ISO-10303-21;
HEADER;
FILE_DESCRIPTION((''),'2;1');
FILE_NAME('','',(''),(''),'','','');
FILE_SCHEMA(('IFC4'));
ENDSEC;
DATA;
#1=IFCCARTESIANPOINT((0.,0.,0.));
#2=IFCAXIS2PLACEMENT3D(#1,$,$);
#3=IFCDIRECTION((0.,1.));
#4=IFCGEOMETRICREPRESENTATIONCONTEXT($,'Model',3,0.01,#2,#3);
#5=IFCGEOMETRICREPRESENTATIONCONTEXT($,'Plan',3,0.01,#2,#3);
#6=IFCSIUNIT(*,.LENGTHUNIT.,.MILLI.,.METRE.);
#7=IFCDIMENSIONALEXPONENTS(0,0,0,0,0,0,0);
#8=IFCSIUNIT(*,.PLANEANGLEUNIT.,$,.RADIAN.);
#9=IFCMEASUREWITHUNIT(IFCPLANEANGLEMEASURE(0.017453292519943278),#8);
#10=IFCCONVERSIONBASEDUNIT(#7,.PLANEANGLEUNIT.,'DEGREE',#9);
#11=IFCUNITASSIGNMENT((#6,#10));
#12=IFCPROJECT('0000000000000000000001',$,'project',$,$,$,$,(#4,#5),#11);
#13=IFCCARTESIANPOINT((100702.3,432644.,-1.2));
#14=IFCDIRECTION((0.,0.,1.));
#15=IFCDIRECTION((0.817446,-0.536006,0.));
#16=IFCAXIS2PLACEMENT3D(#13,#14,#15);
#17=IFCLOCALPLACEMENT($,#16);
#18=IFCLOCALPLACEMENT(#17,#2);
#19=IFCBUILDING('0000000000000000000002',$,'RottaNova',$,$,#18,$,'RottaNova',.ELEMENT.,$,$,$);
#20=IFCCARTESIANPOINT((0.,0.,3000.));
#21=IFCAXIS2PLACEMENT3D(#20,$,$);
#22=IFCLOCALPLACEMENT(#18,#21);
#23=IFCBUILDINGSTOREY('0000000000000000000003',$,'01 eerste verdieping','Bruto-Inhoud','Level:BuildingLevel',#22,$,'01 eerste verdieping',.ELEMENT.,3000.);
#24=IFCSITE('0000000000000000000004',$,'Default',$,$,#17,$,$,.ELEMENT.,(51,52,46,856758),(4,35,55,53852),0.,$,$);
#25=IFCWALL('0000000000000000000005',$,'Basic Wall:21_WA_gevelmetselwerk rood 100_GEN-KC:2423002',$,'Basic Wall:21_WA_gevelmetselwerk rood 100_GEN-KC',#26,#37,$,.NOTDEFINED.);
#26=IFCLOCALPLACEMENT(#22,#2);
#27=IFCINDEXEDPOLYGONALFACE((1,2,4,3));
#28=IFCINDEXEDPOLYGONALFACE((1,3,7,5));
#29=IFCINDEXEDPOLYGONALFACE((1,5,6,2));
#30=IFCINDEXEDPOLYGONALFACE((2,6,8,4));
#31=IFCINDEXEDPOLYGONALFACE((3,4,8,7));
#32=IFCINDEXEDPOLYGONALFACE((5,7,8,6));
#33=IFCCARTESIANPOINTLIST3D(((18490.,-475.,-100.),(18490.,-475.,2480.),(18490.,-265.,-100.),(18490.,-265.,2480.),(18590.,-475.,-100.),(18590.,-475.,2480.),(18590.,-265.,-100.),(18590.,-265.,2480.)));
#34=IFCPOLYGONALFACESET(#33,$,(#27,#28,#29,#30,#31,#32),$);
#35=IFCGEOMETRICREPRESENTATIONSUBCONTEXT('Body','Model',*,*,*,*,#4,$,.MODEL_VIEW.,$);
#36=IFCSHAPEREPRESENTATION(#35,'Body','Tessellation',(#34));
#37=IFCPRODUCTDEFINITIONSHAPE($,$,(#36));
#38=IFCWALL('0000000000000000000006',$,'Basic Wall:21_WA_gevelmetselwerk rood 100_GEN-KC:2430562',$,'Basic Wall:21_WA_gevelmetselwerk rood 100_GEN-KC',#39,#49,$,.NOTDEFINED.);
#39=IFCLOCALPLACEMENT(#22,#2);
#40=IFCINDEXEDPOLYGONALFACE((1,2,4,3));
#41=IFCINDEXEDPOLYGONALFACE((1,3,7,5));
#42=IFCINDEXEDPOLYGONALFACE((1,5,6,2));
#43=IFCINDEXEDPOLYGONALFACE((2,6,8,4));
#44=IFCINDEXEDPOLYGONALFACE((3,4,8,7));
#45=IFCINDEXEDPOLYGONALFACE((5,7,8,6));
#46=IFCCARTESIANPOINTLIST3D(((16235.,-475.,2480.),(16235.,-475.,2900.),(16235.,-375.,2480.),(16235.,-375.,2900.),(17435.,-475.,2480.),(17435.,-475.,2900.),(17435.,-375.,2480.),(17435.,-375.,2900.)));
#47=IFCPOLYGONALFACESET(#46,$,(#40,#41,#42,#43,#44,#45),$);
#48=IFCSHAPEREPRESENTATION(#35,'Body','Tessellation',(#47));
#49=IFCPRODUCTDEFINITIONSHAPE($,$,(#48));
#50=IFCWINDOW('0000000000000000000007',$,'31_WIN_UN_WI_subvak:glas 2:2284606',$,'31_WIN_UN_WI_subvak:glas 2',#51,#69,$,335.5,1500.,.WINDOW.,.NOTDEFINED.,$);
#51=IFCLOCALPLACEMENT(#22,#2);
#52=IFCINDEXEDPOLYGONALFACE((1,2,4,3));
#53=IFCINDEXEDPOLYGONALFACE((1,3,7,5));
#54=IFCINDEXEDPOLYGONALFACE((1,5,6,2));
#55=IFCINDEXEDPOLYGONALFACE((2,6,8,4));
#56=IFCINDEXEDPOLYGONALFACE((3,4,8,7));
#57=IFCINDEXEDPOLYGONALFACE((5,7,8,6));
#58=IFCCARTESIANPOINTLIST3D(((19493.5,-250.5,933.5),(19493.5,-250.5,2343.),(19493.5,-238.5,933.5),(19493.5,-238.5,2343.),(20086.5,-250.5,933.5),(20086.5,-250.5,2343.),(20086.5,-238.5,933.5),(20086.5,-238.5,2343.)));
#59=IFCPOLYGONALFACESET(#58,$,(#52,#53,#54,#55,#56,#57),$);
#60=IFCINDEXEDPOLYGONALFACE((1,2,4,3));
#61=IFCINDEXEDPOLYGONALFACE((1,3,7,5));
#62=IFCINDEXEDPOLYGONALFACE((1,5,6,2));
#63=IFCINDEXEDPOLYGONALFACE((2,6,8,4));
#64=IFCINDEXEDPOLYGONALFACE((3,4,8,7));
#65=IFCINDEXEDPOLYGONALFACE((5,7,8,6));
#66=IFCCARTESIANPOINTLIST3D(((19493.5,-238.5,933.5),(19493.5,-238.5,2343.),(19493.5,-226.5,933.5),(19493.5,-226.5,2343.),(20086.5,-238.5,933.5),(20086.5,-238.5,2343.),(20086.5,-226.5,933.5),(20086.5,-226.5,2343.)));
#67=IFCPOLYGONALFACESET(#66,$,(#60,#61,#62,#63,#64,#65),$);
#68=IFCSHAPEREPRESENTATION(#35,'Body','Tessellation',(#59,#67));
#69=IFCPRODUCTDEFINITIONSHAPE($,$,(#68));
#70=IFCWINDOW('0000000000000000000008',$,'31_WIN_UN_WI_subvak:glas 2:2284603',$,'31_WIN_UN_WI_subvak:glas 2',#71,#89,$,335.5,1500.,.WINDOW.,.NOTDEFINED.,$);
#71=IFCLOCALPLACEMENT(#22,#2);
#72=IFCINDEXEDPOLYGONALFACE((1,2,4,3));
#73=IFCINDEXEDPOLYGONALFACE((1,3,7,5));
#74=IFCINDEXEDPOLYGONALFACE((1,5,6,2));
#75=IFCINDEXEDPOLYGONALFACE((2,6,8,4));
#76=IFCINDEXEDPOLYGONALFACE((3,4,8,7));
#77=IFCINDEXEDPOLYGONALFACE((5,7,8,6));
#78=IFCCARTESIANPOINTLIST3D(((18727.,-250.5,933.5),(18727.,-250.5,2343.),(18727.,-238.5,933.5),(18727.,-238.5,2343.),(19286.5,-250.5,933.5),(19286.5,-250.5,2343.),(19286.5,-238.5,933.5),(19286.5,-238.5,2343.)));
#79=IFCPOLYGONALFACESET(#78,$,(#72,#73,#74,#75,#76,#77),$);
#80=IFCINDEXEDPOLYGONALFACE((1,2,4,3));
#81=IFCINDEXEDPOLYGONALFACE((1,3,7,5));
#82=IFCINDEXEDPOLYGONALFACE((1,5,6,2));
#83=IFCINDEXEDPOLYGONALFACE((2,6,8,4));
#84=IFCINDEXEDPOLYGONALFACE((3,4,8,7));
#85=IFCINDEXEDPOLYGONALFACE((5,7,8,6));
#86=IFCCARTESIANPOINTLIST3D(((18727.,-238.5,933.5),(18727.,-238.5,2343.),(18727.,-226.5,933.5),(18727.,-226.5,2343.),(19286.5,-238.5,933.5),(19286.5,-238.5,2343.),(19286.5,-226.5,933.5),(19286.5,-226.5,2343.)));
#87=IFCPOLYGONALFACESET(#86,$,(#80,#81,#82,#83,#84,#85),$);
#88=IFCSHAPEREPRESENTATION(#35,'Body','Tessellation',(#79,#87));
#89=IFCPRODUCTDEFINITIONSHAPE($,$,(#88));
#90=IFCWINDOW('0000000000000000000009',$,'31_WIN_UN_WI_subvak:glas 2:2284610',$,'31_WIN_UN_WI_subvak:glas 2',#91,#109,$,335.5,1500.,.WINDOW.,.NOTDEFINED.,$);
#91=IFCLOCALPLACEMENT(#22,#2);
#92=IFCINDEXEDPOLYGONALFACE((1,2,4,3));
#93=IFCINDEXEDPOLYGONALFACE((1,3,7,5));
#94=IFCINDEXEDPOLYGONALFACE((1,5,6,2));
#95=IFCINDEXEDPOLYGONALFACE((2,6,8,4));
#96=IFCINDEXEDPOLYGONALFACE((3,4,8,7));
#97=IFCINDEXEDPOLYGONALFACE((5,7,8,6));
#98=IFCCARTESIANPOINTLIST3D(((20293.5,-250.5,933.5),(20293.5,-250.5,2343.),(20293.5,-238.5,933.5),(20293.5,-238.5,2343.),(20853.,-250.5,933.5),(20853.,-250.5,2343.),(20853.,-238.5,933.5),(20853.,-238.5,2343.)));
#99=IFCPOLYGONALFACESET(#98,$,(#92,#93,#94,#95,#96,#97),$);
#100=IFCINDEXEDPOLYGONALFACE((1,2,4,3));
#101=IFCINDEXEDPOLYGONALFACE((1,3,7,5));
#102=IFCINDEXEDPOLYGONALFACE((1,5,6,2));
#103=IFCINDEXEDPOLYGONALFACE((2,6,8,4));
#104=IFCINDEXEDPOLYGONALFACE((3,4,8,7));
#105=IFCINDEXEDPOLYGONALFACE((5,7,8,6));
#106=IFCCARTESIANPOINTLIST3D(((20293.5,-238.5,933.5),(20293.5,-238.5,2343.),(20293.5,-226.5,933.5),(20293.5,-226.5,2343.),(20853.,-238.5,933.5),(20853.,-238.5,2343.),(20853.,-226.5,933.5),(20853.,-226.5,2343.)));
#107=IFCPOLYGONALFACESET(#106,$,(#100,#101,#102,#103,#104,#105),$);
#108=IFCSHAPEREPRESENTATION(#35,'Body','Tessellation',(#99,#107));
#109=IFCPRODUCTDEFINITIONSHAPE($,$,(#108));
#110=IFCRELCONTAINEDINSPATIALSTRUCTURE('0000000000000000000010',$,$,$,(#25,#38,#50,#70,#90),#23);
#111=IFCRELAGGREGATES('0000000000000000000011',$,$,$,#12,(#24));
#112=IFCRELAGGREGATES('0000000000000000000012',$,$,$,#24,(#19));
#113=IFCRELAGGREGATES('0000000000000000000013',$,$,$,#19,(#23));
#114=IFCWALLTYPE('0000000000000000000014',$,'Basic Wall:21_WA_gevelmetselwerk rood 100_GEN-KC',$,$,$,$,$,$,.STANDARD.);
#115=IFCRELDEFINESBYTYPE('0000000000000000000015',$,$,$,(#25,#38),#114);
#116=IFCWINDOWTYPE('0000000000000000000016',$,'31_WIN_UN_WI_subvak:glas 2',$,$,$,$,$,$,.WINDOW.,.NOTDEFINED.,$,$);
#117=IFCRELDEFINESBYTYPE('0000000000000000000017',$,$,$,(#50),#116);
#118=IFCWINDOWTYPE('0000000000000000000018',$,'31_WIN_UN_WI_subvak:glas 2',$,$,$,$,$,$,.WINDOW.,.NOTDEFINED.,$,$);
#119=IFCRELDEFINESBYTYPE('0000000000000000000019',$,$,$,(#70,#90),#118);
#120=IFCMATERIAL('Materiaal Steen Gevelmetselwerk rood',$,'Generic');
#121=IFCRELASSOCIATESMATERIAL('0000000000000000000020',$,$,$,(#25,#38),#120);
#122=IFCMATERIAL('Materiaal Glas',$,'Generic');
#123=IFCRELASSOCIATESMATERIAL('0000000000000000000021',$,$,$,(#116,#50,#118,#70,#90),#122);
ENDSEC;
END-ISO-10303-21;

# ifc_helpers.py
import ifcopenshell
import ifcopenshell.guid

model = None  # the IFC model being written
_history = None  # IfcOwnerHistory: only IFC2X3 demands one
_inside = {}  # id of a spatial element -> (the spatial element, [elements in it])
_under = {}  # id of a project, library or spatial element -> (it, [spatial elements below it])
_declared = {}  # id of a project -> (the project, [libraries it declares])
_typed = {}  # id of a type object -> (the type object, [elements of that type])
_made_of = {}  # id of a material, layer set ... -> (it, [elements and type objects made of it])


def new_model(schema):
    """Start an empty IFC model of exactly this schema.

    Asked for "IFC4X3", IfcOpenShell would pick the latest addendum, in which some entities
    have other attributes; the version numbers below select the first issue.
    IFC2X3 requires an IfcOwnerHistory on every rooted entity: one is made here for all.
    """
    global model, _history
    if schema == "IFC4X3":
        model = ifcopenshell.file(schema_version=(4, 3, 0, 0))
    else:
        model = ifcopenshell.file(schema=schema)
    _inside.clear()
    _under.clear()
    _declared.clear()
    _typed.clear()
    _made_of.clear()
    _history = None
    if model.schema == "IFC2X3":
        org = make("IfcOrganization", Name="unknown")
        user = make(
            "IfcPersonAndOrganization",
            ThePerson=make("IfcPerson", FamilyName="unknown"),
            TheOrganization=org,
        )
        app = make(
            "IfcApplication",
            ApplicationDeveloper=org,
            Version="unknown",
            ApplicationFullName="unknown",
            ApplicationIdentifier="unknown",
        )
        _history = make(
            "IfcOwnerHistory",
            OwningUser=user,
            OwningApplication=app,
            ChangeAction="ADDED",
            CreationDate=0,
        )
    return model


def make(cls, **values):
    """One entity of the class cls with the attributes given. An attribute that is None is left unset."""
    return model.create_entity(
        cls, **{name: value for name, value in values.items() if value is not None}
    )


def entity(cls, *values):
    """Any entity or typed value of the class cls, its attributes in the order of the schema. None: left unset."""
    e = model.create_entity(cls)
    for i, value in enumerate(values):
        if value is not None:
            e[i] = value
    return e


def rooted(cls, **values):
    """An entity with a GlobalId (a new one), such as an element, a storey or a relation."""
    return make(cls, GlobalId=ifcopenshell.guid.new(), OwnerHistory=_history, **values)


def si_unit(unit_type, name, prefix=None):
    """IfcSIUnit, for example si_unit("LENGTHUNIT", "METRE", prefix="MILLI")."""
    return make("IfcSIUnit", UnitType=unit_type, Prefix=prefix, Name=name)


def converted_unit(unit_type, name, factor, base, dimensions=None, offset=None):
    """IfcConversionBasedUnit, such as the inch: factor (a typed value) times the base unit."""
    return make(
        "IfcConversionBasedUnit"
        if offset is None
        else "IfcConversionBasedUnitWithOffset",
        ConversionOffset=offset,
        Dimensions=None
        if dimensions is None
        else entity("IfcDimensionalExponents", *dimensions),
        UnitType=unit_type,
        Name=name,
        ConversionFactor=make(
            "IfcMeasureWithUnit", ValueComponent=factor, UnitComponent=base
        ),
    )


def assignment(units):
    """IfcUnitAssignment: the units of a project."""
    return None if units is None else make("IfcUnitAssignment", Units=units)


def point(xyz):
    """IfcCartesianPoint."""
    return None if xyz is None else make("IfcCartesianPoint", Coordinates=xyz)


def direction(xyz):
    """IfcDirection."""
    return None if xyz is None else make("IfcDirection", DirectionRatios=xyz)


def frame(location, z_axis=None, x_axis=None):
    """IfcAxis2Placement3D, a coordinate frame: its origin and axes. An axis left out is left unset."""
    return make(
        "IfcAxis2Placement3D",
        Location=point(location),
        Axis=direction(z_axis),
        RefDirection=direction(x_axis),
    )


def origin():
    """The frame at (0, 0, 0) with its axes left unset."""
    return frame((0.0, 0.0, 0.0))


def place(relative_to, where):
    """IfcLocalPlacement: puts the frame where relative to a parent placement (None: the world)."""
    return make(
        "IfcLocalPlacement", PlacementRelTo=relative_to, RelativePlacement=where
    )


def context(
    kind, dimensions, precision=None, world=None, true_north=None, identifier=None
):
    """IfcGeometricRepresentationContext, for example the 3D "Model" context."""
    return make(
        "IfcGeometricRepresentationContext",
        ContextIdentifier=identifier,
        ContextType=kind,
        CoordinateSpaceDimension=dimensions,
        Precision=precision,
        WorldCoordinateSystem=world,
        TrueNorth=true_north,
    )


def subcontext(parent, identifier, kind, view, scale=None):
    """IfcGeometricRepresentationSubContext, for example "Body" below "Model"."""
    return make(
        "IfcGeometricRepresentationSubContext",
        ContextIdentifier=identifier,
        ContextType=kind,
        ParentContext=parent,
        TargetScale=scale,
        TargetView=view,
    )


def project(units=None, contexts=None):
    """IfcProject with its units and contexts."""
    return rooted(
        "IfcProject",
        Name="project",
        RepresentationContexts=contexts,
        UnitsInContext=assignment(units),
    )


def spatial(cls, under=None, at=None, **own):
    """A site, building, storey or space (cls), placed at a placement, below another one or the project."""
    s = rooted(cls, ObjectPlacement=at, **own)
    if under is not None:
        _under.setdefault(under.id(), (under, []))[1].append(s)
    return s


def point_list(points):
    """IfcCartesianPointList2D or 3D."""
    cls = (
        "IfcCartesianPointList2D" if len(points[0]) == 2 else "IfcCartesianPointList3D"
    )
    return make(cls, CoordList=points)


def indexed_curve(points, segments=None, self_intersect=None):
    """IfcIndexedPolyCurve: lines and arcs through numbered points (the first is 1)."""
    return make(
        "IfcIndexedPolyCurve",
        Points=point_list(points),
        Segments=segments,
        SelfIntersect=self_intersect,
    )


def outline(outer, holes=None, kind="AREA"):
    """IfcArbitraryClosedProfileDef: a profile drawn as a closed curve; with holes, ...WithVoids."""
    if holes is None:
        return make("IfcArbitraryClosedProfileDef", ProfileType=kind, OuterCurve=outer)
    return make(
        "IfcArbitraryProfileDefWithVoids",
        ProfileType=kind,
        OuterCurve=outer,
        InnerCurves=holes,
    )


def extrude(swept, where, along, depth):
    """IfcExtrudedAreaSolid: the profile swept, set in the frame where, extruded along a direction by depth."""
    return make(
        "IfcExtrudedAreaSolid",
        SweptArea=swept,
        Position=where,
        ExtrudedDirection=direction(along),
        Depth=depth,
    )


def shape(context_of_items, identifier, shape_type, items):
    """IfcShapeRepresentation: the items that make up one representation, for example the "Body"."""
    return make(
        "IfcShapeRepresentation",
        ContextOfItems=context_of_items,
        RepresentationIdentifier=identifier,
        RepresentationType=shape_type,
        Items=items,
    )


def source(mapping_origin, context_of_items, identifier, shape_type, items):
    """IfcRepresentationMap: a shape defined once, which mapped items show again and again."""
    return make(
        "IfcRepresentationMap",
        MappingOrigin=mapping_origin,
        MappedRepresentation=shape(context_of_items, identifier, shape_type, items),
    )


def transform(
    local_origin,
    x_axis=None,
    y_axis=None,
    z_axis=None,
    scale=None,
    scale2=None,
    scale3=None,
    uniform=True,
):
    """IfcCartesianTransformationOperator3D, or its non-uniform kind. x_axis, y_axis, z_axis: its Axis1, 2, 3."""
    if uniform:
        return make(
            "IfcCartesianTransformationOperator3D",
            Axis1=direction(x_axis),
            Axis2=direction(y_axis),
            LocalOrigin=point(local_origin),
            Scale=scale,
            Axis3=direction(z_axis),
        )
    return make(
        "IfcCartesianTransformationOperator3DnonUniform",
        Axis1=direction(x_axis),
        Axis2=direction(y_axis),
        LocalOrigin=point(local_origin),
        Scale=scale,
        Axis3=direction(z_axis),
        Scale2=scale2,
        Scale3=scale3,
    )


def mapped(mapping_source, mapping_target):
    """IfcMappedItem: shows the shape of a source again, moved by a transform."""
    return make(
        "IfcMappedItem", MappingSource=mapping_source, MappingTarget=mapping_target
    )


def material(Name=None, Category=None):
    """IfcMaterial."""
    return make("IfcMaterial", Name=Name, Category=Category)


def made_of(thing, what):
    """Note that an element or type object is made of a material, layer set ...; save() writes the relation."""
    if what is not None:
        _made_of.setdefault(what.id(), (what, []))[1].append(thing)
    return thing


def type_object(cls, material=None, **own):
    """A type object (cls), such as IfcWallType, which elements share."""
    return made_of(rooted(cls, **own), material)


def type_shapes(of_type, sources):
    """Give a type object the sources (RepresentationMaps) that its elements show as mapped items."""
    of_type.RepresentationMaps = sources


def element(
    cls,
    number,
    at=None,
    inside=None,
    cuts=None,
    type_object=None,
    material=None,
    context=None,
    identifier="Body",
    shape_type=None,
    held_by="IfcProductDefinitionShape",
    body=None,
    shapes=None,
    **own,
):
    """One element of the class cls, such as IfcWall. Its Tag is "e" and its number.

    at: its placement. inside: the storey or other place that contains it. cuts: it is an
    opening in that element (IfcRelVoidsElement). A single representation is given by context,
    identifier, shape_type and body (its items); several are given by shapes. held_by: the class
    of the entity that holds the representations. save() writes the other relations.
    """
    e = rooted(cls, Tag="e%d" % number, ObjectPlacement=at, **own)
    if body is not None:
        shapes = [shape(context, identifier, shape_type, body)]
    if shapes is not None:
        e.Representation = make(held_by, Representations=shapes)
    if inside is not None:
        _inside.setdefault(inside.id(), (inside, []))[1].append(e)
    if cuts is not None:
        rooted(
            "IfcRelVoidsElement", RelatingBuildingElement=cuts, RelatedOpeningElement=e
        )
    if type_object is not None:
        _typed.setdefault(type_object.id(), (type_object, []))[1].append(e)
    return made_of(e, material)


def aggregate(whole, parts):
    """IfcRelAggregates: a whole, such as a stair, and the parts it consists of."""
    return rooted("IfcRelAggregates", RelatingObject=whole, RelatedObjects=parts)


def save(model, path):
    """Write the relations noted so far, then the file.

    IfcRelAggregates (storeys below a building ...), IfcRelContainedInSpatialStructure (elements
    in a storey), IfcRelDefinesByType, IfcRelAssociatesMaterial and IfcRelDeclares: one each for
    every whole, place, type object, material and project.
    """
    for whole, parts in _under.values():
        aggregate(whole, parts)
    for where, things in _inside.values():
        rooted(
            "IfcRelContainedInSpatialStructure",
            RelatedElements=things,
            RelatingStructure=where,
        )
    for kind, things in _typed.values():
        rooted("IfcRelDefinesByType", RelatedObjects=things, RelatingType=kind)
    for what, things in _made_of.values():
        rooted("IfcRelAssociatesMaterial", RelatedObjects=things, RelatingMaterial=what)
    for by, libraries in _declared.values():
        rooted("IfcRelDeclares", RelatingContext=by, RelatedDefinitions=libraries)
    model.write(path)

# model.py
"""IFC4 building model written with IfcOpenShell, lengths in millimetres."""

from ifc_helpers import new_model, entity, si_unit, converted_unit, direction, frame, origin, place, context, subcontext, project, spatial, indexed_curve, outline, extrude, source, transform, mapped, material, type_object, type_shapes, element, save


model = new_model("IFC4")

# Units and contexts
model_context = context("Model", 3, precision=0.01, world=origin(), true_north=direction((0.0, 1.0)))
plan_context = context("Plan", 3, precision=0.01, world=origin(), true_north=direction((0.0, 1.0)))
body_context = subcontext(model_context, "Body", "Model", "MODEL_VIEW")
ifc_project = project(units=[si_unit("LENGTHUNIT", "METRE", prefix="MILLI"), converted_unit("PLANEANGLEUNIT", "DEGREE", entity("IfcPlaneAngleMeasure", 0.017453292519943278), si_unit("PLANEANGLEUNIT", "RADIAN"), dimensions=[0, 0, 0, 0, 0, 0, 0])], contexts=[model_context, plan_context])

# Site, building, storey
site_placement = place(None, frame((100702.3, 432644.0, -1.2), z_axis=(0.0, 0.0, 1.0), x_axis=(0.817446, -0.536006, 0.0)))
site = spatial("IfcSite", under=ifc_project, at=site_placement, Name="Default", CompositionType="ELEMENT", RefLatitude=(51, 52, 46, 856758), RefLongitude=(4, 35, 55, 53852), RefElevation=0.0)
building_placement = place(site_placement, origin())
building = spatial("IfcBuilding", under=site, at=building_placement, Name="RottaNova", LongName="RottaNova", CompositionType="ELEMENT")
storey_placement = place(building_placement, frame((0.0, 0.0, 3000.0)))
storey = spatial("IfcBuildingStorey", under=building, at=storey_placement, Name="01 eerste verdieping", Description="Bruto-Inhoud", ObjectType="Level:BuildingLevel", LongName="01 eerste verdieping", CompositionType="ELEMENT", Elevation=3000.0)

# Shared definitions
ifc_material_1 = material(Name="Materiaal Glas", Category="Generic")

# Walls
ifc_material_2 = material(Name="Materiaal Steen Gevelmetselwerk rood", Category="Generic")
wall_type = type_object("IfcWallType", Name="Basic Wall:21_WA_gevelmetselwerk rood 100_GEN-KC", PredefinedType="STANDARD")
wall_1_placement = place(storey_placement, frame((18540.0, -265.0, -100.0), z_axis=(0.0, 0.0, 1.0), x_axis=(0.0, -1.0, 0.0)))
element("IfcWall", 1, at=wall_1_placement, inside=storey, type_object=wall_type, material=ifc_material_2, Name="Basic Wall:21_WA_gevelmetselwerk rood 100_GEN-KC:2423002", ObjectType="Basic Wall:21_WA_gevelmetselwerk rood 100_GEN-KC", PredefinedType="NOTDEFINED", context=body_context, shape_type="SweptSolid", body=[
    extrude(outline(indexed_curve([(210.0, 50.0), (0.0, 50.0), (0.0, -50.0), (210.0, -50.0), (210.0, 50.0)], self_intersect=False)), origin(), (0.0, 0.0, 1.0), 2580.0),
])
wall_2_placement = place(storey_placement, frame((17435.0, -425.0, 2480.0), z_axis=(0.0, 0.0, 1.0), x_axis=(-1.0, 0.0, 0.0)))
element("IfcWall", 2, at=wall_2_placement, inside=storey, type_object=wall_type, material=ifc_material_2, Name="Basic Wall:21_WA_gevelmetselwerk rood 100_GEN-KC:2430562", ObjectType="Basic Wall:21_WA_gevelmetselwerk rood 100_GEN-KC", PredefinedType="NOTDEFINED", context=body_context, shape_type="SweptSolid", body=[
    extrude(outline(indexed_curve([(1200.0, 50.0), (0.0, 50.0), (0.0, -50.0), (1200.0, -50.0), (1200.0, 50.0)], self_intersect=False)), origin(), (0.0, 0.0, 1.0), 420.0),
])

# Windows
window_type_1 = type_object("IfcWindowType", Name="31_WIN_UN_WI_subvak:glas 2", PartitioningType="NOTDEFINED", PredefinedType="WINDOW", material=ifc_material_1)
shared_shape_1 = source(origin(), body_context, "Body", "SweptSolid", [
    extrude(outline(indexed_curve([(-296.5, -6.0), (296.5, -6.0), (296.5, 6.0), (-296.5, 6.0), (-296.5, -6.0)], self_intersect=False)), frame((0.0, -6.0, 0.0)), (0.0, 0.0, 1.0), 1409.5),
    extrude(outline(indexed_curve([(-296.5, -6.0), (296.5, -6.0), (296.5, 6.0), (-296.5, 6.0), (-296.5, -6.0)], self_intersect=False)), frame((0.0, 6.0, 0.0)), (0.0, 0.0, 1.0), 1409.5),
])
type_shapes(window_type_1, [shared_shape_1])
window_1_placement = place(storey_placement, frame((19790.0, -238.5, 933.5)))
element("IfcWindow", 3, at=window_1_placement, inside=storey, type_object=window_type_1, material=ifc_material_1, Name="31_WIN_UN_WI_subvak:glas 2:2284606", ObjectType="31_WIN_UN_WI_subvak:glas 2", OverallHeight=335.5, OverallWidth=1500.0, PartitioningType="NOTDEFINED", PredefinedType="WINDOW", context=body_context, shape_type="MappedRepresentation", body=[
    mapped(shared_shape_1, transform((0.0, 0.0, 0.0), scale=1.0)),
])
window_type_2 = type_object("IfcWindowType", Name="31_WIN_UN_WI_subvak:glas 2", PartitioningType="NOTDEFINED", PredefinedType="WINDOW", material=ifc_material_1)
shared_shape_2 = source(origin(), body_context, "Body", "SweptSolid", [
    extrude(outline(indexed_curve([(-279.8, -6.0), (279.8, -6.0), (279.8, 6.0), (-279.8, 6.0), (-279.8, -6.0)], self_intersect=False)), frame((0.0, -6.0, 0.0)), (0.0, 0.0, 1.0), 1409.5),
    extrude(outline(indexed_curve([(-279.8, -6.0), (279.8, -6.0), (279.8, 6.0), (-279.8, 6.0), (-279.8, -6.0)], self_intersect=False)), frame((0.0, 6.0, 0.0)), (0.0, 0.0, 1.0), 1409.5),
])
type_shapes(window_type_2, [shared_shape_2])
for number, where, name in (
    (4, (19006.8, -238.5, 933.5), "31_WIN_UN_WI_subvak:glas 2:2284603"),
    (5, (20573.3, -238.5, 933.5), "31_WIN_UN_WI_subvak:glas 2:2284610"),
):
    element("IfcWindow", number, at=place(storey_placement, frame(where)), inside=storey, type_object=window_type_2, material=ifc_material_1, Name=name, ObjectType="31_WIN_UN_WI_subvak:glas 2", OverallHeight=335.5, OverallWidth=1500.0, PartitioningType="NOTDEFINED", PredefinedType="WINDOW", context=body_context, shape_type="MappedRepresentation", body=[
        mapped(shared_shape_2, transform((0.0, 0.0, 0.0), scale=1.0)),
    ])

save(model, "model.ifc")
